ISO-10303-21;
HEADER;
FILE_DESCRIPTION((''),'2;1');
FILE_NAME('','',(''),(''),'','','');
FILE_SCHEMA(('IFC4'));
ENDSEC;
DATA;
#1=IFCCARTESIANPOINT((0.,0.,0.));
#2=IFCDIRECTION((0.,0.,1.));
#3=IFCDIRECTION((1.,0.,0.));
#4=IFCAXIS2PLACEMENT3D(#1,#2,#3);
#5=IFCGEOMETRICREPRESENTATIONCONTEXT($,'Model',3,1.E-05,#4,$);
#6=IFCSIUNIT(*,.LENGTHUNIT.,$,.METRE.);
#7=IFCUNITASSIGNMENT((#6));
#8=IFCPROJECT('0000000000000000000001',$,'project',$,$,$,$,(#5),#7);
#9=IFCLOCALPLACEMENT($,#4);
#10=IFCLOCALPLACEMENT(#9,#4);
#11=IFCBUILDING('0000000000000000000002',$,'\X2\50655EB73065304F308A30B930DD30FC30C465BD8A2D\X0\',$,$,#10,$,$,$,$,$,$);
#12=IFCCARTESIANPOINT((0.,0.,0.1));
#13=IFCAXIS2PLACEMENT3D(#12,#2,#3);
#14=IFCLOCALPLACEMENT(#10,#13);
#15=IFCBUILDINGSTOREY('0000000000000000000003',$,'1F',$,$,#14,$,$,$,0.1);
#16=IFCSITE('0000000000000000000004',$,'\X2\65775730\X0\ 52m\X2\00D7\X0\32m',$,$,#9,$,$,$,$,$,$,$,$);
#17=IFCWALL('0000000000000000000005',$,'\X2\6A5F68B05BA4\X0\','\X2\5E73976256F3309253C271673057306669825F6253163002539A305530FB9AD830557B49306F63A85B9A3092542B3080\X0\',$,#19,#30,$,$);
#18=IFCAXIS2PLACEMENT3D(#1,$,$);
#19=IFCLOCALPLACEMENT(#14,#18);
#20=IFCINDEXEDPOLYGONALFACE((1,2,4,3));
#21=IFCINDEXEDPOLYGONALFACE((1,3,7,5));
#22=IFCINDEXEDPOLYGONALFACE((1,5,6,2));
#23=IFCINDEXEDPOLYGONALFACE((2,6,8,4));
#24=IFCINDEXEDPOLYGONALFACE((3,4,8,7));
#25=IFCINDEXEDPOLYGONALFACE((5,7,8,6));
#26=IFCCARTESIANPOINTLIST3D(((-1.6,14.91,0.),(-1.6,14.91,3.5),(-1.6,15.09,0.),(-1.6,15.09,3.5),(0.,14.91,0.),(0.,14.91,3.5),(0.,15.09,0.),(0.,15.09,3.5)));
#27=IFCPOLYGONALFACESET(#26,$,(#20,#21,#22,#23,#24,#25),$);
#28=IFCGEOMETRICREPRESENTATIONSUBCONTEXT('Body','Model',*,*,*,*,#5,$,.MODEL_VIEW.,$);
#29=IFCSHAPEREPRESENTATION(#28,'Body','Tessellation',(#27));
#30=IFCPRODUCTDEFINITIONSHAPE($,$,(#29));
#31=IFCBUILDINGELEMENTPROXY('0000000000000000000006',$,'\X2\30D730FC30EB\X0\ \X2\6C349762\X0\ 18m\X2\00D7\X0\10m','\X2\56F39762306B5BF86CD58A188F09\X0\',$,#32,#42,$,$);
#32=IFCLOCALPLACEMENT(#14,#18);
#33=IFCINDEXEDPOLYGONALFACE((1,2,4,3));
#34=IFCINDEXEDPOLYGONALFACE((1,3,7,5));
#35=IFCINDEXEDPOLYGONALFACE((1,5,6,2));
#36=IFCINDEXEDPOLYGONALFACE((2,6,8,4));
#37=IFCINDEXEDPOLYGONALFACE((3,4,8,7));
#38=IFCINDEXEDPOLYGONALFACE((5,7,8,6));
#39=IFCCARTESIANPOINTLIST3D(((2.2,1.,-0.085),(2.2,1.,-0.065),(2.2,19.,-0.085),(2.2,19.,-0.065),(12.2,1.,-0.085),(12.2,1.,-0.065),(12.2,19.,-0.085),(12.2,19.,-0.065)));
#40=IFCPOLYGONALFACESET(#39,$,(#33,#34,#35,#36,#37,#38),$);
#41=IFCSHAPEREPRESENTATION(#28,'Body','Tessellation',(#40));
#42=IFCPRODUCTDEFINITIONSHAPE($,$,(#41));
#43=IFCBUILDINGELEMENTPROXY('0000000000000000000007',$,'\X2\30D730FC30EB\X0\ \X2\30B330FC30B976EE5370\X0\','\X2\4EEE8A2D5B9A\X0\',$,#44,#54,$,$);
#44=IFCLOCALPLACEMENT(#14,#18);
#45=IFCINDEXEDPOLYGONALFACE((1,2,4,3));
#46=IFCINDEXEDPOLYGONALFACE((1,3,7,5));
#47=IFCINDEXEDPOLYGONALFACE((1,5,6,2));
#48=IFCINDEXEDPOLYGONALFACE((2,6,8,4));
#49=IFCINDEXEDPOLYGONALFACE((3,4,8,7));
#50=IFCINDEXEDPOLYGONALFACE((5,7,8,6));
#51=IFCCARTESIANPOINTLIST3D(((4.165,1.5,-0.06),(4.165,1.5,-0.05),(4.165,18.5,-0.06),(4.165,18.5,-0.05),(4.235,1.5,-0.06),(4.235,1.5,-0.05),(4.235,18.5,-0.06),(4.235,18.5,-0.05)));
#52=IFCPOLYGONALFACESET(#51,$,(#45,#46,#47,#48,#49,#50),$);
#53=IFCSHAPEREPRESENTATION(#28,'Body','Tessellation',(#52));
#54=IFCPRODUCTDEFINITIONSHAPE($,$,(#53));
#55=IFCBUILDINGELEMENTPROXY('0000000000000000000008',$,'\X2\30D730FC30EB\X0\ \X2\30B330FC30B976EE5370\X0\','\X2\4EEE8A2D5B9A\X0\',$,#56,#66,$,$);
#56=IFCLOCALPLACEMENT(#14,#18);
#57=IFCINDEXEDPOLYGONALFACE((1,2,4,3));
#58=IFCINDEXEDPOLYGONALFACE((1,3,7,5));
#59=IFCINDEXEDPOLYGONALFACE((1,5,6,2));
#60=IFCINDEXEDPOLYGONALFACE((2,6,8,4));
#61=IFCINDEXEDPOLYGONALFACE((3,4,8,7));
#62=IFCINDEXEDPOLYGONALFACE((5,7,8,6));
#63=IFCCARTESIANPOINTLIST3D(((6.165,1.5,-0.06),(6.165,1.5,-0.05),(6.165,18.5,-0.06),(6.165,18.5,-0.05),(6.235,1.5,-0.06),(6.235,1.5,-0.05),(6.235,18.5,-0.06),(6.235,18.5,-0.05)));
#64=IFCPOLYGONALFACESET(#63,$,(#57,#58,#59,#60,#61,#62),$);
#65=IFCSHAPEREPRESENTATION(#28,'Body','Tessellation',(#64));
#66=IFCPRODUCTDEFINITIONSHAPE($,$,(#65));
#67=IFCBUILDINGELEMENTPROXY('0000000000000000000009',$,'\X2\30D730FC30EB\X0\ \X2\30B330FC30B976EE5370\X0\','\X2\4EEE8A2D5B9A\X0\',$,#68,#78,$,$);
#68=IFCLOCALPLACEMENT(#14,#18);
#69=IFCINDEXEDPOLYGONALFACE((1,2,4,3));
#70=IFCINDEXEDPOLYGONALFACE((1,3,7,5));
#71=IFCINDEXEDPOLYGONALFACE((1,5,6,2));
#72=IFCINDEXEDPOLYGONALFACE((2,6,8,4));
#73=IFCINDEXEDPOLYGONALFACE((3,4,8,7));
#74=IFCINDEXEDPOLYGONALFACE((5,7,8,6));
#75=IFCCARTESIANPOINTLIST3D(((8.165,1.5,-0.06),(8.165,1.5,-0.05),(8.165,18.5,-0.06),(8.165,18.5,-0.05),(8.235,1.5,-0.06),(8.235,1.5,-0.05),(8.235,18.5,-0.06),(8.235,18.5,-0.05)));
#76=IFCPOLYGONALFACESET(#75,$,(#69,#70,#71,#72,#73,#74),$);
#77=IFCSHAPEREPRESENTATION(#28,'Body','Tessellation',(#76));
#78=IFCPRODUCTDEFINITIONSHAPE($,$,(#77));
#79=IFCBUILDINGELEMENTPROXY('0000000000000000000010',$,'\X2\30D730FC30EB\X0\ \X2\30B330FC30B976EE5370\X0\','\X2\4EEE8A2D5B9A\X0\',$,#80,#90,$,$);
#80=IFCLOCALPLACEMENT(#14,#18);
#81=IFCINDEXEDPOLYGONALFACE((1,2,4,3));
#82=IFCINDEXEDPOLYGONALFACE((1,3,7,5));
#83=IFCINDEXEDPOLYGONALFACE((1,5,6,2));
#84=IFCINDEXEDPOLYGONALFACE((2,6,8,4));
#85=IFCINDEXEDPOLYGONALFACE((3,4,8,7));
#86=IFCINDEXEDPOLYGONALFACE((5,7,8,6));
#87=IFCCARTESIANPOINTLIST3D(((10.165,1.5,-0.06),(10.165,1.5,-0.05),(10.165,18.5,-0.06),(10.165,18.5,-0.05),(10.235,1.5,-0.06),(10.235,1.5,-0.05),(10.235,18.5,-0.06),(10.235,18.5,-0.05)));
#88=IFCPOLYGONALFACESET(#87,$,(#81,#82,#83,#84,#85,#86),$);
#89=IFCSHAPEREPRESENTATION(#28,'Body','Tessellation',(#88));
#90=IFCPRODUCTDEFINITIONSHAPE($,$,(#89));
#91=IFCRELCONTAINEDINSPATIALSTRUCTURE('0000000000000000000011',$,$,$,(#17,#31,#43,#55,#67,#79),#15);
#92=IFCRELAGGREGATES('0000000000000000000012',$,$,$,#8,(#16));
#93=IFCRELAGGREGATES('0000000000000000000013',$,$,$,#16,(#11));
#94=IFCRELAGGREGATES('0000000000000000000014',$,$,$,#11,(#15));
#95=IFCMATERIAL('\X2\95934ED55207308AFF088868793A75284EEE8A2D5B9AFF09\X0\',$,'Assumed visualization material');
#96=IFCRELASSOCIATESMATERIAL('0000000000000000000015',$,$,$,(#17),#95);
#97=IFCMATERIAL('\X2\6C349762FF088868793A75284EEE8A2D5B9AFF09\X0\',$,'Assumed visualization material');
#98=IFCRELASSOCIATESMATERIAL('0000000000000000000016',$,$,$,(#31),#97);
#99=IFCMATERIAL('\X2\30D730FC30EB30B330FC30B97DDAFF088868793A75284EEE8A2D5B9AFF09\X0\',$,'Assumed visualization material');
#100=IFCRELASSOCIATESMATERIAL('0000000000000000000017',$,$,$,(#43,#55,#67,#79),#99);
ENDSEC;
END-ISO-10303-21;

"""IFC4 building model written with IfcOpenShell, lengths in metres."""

from ifc_helpers import new_model, si_unit, frame, origin_with_axes, place, context, subcontext, project, spatial, rectangle, extrude, material, element, save


model = new_model("IFC4")

# Units and contexts
model_context = context("Model", 3, precision=1e-05, world=origin_with_axes())
body_context = subcontext(model_context, "Body", "Model", "MODEL_VIEW")
ifc_project = project(units=[si_unit("LENGTHUNIT", "METRE")], contexts=[model_context])

# Site, building, storey
site_placement = place(None, origin_with_axes())
site = spatial("IfcSite", under=ifc_project, at=site_placement, Name="敷地 52m×32m")
building_placement = place(site_placement, origin_with_axes())
building = spatial("IfcBuilding", under=site, at=building_placement, Name="健康づくりスポーツ施設")
storey_placement = place(building_placement, frame((0.0, 0.0, 0.1), z_axis=(0.0, 0.0, 1.0), x_axis=(1.0, 0.0, 0.0)))
storey = spatial("IfcBuildingStorey", under=building, at=storey_placement, Name="1F", Elevation=0.1)

# Wall
ifc_material_1 = material(Name="間仕切り（表示用仮設定）", Category="Assumed visualization material")
wall_1_placement = place(storey_placement, frame((-0.8, 15.0, 0.0), z_axis=(0.0, 0.0, 1.0), x_axis=(1.0, 0.0, 0.0)))
element("IfcWall", 1, at=wall_1_placement, inside=storey, material=ifc_material_1, Name="機械室", Description="平面図を参照して概形化。厚さ・高さ等は推定を含む", context=body_context, shape_type="SweptSolid", body=[
    extrude(rectangle(XDim=1.6, YDim=0.18), origin_with_axes(), (0.0, 0.0, 1.0), 3.5),
])

# Building element proxies
ifc_material_2 = material(Name="水面（表示用仮設定）", Category="Assumed visualization material")
proxy_placement = place(storey_placement, frame((7.2, 10.0, -0.085), z_axis=(0.0, 0.0, 1.0), x_axis=(1.0, 0.0, 0.0)))
element("IfcBuildingElementProxy", 2, at=proxy_placement, inside=storey, material=ifc_material_2, Name="プール 水面 18m×10m", Description="図面に寸法記載", context=body_context, shape_type="SweptSolid", body=[
    extrude(rectangle(XDim=10.0, YDim=18.0), origin_with_axes(), (0.0, 0.0, 1.0), 0.02),
])
ifc_material_3 = material(Name="プールコース線（表示用仮設定）", Category="Assumed visualization material")
for number, where, z_axis, x_axis, name in (
    (3, (4.2, 10.0, -0.06), (0.0, 0.0, 1.0), (1.0, 0.0, 0.0), "プール コース目印"),
    (4, (6.2, 10.0, -0.06), (0.0, 0.0, 1.0), (1.0, 0.0, 0.0), "プール コース目印"),
    (5, (8.2, 10.0, -0.06), (0.0, 0.0, 1.0), (1.0, 0.0, 0.0), "プール コース目印"),
    (6, (10.2, 10.0, -0.06), (0.0, 0.0, 1.0), (1.0, 0.0, 0.0), "プール コース目印"),
):
    element("IfcBuildingElementProxy", number, at=place(storey_placement, frame(where, z_axis=z_axis, x_axis=x_axis)), inside=storey, material=ifc_material_3, Name=name, Description="仮設定", context=body_context, shape_type="SweptSolid", body=[
        extrude(rectangle(XDim=0.07, YDim=17.0), origin_with_axes(), (0.0, 0.0, 1.0), 0.01),
    ])

save(model, "model.ifc")
